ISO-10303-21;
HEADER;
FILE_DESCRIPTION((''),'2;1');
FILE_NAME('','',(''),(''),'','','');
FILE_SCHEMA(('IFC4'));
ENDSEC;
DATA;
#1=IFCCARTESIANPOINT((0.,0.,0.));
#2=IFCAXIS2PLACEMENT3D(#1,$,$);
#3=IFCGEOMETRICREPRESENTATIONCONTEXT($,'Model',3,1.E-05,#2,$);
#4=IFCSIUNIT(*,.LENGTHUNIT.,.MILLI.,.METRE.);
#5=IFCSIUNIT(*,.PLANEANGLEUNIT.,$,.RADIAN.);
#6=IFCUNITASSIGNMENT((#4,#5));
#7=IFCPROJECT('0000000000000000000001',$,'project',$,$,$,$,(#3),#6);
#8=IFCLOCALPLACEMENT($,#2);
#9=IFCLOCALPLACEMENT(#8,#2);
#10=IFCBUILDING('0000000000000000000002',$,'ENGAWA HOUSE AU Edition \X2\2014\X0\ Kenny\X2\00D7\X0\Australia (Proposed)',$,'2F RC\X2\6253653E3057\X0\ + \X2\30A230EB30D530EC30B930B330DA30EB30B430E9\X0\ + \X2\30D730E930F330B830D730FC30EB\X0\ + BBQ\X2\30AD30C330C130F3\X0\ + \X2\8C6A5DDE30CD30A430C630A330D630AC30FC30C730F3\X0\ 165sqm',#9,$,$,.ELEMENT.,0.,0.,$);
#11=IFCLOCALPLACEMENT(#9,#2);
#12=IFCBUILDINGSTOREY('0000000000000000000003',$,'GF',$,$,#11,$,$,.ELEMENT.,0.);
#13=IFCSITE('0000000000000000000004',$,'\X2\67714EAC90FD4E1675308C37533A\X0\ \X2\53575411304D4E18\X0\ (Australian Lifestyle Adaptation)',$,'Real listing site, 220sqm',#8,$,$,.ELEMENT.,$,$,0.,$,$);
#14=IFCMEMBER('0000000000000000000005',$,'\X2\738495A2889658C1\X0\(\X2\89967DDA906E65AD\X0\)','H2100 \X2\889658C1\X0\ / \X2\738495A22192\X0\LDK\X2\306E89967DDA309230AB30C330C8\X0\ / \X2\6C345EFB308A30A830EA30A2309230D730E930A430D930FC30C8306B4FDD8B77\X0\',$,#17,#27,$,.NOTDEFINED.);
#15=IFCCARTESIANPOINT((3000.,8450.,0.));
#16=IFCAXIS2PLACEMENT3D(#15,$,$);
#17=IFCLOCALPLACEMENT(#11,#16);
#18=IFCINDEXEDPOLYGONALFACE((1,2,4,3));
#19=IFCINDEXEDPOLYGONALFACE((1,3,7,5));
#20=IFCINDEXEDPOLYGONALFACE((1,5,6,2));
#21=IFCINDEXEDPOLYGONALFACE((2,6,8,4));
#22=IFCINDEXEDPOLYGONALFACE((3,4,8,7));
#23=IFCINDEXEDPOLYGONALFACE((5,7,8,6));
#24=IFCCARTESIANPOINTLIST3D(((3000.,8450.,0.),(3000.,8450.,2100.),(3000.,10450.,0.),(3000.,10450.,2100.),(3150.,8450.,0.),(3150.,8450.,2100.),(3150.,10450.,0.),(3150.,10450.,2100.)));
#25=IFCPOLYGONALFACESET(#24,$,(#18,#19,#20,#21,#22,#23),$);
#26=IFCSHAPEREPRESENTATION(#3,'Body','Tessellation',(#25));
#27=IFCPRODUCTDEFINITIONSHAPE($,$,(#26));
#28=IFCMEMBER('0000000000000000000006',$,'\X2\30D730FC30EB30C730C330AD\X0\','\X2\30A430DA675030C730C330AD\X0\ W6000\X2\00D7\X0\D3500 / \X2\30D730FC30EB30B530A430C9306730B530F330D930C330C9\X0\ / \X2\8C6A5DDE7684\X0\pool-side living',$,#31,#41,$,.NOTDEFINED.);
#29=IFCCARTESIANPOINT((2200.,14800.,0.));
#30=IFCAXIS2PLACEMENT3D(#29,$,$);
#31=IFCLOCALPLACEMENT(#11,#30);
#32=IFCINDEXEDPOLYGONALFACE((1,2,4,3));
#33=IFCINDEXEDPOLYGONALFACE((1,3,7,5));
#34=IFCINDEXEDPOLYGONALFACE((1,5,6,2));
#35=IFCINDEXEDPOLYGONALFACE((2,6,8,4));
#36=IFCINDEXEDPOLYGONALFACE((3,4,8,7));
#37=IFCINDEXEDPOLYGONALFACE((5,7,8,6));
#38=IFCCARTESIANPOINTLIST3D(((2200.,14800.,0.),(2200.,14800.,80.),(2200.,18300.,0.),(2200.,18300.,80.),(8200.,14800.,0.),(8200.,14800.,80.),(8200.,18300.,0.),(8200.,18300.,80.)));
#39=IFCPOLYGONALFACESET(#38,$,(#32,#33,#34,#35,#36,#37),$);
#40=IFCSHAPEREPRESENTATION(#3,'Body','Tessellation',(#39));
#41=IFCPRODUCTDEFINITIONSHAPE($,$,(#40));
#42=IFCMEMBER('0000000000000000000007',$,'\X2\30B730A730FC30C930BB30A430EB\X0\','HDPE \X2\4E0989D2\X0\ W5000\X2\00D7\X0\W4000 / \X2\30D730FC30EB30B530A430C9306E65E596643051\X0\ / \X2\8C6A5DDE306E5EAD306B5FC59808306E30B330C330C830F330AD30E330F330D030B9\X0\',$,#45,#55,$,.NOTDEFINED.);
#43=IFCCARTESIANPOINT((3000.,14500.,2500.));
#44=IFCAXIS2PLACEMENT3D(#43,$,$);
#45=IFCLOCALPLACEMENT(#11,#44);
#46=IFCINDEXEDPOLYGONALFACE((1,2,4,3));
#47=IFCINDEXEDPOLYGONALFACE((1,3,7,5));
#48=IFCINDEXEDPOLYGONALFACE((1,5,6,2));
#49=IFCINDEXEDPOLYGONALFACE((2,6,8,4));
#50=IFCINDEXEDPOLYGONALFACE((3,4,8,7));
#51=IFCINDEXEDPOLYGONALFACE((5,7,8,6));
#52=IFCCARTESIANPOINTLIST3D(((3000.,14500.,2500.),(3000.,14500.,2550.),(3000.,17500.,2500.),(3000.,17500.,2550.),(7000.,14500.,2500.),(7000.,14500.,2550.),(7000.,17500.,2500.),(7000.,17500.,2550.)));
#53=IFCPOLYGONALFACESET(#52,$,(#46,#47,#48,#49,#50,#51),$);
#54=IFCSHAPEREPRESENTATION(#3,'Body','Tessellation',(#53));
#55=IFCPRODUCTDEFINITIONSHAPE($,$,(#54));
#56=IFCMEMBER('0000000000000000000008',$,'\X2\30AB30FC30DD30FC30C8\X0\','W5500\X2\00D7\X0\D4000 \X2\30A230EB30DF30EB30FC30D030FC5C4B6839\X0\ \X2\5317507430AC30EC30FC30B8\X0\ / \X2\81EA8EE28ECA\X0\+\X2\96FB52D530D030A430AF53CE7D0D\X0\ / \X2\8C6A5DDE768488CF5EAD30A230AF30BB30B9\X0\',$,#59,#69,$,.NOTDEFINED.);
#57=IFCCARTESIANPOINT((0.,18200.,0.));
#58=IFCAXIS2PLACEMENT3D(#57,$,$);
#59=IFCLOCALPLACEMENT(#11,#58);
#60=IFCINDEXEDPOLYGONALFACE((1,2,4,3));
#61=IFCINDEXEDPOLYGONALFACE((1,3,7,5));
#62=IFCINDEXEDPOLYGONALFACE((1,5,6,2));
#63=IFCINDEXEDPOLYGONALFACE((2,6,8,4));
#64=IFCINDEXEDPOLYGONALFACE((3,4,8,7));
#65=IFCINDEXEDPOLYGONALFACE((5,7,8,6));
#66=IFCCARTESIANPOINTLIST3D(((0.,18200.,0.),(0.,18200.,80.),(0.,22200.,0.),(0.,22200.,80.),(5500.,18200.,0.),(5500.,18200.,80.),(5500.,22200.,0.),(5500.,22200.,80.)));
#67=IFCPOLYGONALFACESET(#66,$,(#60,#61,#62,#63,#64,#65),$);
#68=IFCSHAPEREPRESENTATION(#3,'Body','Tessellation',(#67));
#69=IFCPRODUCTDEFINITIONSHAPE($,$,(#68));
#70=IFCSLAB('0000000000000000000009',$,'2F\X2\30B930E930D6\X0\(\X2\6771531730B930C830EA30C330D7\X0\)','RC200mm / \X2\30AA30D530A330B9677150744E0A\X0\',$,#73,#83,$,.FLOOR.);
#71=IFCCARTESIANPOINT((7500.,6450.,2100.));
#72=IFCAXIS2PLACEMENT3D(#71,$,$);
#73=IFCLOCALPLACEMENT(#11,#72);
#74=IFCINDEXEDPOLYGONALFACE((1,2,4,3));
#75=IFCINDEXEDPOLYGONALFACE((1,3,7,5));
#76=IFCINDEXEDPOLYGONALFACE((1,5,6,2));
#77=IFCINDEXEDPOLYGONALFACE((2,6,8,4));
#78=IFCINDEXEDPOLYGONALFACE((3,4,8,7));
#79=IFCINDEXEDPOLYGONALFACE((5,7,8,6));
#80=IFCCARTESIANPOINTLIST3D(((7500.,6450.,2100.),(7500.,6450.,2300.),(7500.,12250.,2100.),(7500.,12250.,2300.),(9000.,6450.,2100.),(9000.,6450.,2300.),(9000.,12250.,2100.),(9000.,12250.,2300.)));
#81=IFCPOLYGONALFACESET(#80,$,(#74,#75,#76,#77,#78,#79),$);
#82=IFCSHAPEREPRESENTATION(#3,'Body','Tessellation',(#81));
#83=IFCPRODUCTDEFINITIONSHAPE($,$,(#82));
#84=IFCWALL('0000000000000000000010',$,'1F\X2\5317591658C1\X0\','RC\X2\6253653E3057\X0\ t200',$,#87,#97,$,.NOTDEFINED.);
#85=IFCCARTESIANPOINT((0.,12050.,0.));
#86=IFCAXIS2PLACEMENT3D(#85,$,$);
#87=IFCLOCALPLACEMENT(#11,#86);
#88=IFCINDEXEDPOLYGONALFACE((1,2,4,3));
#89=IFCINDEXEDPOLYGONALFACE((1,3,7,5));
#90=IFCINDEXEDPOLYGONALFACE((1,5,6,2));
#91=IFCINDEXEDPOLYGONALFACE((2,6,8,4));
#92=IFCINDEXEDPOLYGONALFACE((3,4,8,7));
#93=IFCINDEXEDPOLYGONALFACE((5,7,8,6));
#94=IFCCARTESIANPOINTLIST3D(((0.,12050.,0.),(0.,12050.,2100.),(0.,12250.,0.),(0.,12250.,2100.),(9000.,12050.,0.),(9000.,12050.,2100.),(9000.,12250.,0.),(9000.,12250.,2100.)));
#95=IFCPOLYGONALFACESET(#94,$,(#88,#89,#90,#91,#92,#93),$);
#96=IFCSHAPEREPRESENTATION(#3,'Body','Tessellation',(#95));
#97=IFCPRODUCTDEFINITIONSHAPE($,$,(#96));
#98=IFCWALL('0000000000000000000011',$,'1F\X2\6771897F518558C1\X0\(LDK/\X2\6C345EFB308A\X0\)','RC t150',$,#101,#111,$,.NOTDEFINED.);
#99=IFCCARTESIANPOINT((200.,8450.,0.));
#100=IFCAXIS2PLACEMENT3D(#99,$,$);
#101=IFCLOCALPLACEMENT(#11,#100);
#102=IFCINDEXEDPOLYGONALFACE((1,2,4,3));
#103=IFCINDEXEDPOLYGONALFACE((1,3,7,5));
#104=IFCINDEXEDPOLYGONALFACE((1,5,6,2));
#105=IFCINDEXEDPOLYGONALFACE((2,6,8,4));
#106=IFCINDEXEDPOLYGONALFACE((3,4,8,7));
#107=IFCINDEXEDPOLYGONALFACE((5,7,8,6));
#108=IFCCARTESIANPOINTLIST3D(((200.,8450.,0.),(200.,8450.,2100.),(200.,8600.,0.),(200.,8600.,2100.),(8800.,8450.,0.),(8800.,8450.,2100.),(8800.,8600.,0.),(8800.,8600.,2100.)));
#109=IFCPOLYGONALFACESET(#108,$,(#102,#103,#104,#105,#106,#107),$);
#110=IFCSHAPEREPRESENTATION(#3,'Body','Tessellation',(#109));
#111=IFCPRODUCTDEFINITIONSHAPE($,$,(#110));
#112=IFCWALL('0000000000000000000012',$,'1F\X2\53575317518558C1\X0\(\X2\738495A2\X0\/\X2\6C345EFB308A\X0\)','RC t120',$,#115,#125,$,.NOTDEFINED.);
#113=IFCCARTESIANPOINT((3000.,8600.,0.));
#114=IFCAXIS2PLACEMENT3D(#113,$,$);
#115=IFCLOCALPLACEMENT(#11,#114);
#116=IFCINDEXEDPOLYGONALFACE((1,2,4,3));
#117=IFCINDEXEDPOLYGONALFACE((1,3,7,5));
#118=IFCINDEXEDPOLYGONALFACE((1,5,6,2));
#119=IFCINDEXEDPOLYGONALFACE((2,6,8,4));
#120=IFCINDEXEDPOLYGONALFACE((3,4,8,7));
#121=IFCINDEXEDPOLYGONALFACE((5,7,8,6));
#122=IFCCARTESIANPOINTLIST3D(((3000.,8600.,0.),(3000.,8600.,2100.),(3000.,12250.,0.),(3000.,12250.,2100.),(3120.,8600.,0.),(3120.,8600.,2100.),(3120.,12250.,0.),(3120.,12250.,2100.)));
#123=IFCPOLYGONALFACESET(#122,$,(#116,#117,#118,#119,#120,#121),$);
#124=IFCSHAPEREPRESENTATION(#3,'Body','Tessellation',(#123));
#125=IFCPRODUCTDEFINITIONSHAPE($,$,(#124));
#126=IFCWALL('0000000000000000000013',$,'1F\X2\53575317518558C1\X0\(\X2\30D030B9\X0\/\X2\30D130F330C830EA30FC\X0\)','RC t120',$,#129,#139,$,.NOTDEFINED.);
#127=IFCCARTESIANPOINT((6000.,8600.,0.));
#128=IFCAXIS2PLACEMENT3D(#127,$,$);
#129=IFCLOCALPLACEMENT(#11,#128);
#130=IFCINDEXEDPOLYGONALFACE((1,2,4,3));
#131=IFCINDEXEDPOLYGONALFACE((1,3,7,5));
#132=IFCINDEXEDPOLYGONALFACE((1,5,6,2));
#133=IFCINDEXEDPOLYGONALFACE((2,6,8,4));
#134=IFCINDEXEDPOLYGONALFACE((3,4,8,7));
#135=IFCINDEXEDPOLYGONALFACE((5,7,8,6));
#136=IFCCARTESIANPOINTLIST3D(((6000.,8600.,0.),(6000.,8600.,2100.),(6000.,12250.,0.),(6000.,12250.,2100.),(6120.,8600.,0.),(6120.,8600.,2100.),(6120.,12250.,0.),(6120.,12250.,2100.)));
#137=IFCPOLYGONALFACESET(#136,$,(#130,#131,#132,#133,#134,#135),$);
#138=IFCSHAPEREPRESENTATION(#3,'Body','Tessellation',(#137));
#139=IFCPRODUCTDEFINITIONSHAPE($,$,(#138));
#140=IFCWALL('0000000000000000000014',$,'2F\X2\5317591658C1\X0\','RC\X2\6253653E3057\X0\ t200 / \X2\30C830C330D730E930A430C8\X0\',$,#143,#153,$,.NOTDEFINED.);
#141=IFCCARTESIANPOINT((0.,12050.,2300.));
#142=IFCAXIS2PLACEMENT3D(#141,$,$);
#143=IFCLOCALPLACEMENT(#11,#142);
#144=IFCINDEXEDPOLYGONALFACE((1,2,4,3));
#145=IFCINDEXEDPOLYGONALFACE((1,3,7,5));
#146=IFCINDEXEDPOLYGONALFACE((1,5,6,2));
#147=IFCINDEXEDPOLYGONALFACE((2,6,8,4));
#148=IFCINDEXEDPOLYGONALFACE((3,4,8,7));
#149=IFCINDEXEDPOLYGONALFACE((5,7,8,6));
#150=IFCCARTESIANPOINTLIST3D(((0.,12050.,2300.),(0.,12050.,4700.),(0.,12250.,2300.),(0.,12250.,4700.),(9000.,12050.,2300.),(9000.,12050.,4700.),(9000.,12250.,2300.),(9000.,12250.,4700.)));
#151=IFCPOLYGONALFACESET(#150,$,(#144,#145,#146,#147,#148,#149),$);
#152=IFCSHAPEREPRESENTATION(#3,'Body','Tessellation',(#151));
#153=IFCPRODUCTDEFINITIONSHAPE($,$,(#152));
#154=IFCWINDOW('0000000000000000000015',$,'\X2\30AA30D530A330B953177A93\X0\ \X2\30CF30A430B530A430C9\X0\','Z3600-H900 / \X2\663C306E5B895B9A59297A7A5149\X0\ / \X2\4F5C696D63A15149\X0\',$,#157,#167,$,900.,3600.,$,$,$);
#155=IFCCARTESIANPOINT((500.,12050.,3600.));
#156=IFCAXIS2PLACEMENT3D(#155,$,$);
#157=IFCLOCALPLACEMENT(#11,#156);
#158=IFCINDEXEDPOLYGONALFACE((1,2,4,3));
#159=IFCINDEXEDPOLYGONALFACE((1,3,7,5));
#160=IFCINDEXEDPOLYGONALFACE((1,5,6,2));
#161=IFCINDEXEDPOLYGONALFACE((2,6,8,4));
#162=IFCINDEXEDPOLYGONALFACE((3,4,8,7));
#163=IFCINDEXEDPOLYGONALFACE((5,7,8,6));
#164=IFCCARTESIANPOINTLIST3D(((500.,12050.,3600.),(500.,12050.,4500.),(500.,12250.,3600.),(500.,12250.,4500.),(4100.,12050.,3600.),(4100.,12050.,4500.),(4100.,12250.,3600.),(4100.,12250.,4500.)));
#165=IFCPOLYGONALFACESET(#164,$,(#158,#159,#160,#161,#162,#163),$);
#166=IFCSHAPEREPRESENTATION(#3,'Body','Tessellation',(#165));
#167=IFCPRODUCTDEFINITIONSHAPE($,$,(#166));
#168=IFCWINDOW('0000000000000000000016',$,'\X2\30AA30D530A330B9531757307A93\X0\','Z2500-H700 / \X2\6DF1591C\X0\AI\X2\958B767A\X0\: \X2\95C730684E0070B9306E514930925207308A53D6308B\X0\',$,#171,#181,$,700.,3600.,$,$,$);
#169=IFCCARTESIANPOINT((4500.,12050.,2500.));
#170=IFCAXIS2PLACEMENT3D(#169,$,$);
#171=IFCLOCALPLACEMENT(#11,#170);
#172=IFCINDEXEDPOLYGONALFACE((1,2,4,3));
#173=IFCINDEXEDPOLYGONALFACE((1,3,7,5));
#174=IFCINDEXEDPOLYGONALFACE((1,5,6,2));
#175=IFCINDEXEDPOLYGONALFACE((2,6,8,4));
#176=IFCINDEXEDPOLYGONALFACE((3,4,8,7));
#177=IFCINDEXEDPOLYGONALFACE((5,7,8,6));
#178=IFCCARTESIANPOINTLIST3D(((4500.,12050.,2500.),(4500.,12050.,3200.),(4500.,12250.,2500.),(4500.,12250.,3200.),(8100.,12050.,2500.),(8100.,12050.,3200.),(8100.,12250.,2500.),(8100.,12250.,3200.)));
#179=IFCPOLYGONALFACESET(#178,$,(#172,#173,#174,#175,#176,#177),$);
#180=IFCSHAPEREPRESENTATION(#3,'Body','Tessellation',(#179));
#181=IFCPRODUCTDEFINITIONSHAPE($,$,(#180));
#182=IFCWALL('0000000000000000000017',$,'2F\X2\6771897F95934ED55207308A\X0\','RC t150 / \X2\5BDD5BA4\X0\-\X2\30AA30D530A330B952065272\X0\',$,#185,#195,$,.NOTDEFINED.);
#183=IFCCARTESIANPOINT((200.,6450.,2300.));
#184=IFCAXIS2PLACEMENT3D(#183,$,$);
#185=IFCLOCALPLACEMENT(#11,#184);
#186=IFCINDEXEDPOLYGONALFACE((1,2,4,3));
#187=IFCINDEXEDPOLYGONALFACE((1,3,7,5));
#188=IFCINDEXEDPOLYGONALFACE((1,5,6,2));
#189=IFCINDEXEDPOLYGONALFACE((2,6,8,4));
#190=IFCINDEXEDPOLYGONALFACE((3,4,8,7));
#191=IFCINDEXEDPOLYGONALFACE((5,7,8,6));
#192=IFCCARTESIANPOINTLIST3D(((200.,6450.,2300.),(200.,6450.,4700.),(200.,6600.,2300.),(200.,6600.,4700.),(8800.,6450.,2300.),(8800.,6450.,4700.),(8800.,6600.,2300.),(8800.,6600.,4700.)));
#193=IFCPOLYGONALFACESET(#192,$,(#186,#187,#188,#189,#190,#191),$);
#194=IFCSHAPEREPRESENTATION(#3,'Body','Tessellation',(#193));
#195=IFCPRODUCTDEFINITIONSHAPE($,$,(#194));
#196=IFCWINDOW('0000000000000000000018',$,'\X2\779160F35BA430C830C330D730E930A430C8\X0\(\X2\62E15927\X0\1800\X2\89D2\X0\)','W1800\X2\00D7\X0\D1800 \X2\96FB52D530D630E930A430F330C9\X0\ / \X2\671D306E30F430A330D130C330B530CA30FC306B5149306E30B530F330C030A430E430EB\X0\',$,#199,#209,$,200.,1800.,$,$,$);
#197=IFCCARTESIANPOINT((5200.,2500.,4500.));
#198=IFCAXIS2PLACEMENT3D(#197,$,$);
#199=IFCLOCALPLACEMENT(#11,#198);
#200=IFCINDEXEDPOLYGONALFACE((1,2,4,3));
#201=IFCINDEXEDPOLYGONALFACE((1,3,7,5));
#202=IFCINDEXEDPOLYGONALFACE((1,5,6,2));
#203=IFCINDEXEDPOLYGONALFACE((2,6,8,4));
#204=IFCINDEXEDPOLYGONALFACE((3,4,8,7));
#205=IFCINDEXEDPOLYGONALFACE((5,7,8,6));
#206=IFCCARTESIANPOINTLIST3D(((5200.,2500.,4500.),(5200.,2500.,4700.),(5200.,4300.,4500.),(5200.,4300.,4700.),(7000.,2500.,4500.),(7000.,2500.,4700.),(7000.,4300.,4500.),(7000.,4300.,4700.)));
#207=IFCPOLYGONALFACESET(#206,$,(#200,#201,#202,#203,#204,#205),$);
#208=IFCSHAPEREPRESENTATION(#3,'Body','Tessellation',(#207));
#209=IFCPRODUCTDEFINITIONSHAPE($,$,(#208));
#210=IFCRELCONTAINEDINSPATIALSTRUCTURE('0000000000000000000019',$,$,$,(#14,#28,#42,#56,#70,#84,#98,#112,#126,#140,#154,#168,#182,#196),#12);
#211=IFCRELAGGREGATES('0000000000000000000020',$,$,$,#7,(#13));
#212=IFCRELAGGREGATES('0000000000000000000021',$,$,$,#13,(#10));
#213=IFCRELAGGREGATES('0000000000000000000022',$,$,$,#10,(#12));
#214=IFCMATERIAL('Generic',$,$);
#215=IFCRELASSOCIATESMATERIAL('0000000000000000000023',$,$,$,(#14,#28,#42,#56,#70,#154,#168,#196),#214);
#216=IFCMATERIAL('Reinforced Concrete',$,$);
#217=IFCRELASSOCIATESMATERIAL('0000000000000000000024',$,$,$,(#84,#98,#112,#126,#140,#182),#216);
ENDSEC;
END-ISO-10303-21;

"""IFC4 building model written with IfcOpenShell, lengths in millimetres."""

from ifc_helpers import new_model, si_unit, frame, frame_2d, origin, place, context, project, spatial, rectangle, extrude, material, element, fill, save


model = new_model("IFC4")

# Units and contexts
model_context = context("Model", 3, precision=1e-05, world=origin())
ifc_project = project(units=[si_unit("LENGTHUNIT", "METRE", prefix="MILLI"), si_unit("PLANEANGLEUNIT", "RADIAN")], contexts=[model_context])

# Site, building, storey
site_placement = place(None, origin())
site = spatial("IfcSite", under=ifc_project, at=site_placement, Name="東京都世田谷区 南向き丘 (Australian Lifestyle Adaptation)", ObjectType="Real listing site, 220sqm", CompositionType="ELEMENT", RefElevation=0.0)
building_placement = place(site_placement, origin())
building = spatial("IfcBuilding", under=site, at=building_placement, Name="ENGAWA HOUSE AU Edition — Kenny×Australia (Proposed)", ObjectType="2F RC打放し + アルフレスコペルゴラ + プランジプール + BBQキッチン + 豪州ネイティブガーデン 165sqm", CompositionType="ELEMENT", ElevationOfRefHeight=0.0, ElevationOfTerrain=0.0)
storey_placement = place(building_placement, origin())
storey = spatial("IfcBuildingStorey", under=building, at=storey_placement, Name="GF", CompositionType="ELEMENT", Elevation=0.0)

# Members
ifc_material_1 = material(Name="Generic")
member_1_placement = place(storey_placement, frame((3000.0, 8450.0, 0.0)))
element("IfcMember", 1, at=member_1_placement, inside=storey, material=ifc_material_1, Name="玄関袖壁(視線遮断)", Description="H2100 袖壁 / 玄関→LDKの視線をカット / 水廻りエリアをプライベートに保護", PredefinedType="NOTDEFINED", context=model_context, shape_type="SweptSolid", body=[
    extrude(rectangle(XDim=150.0, YDim=2000.0, at=frame_2d((75.0, 1000.0))), frame((3000.0, 8450.0, 0.0)), (0.0, 0.0, 1.0), 2100.0),
])
member_2_placement = place(storey_placement, frame((2200.0, 14800.0, 0.0)))
element("IfcMember", 2, at=member_2_placement, inside=storey, material=ifc_material_1, Name="プールデッキ", Description="イペ材デッキ W6000×D3500 / プールサイドでサンベッド / 豪州的pool-side living", PredefinedType="NOTDEFINED", context=model_context, shape_type="SweptSolid", body=[
    extrude(rectangle(XDim=6000.0, YDim=3500.0, at=frame_2d((3000.0, 1750.0))), frame((2200.0, 14800.0, 0.0)), (0.0, 0.0, 1.0), 80.0),
])
member_3_placement = place(storey_placement, frame((3000.0, 14500.0, 2500.0)))
element("IfcMember", 3, at=member_3_placement, inside=storey, material=ifc_material_1, Name="シェードセイル", Description="HDPE 三角 W5000×W4000 / プールサイドの日除け / 豪州の庭に必須のコットンキャンバス", PredefinedType="NOTDEFINED", context=model_context, shape_type="SweptSolid", body=[
    extrude(rectangle(XDim=4000.0, YDim=3000.0, at=frame_2d((2000.0, 1500.0))), frame((3000.0, 14500.0, 2500.0)), (0.0, 0.0, 1.0), 50.0),
])
member_4_placement = place(storey_placement, frame((0.0, 18200.0, 0.0)))
element("IfcMember", 4, at=member_4_placement, inside=storey, material=ifc_material_1, Name="カーポート", Description="W5500×D4000 アルミルーバー屋根 北側ガレージ / 自転車+電動バイク収納 / 豪州的裏庭アクセス", PredefinedType="NOTDEFINED", context=model_context, shape_type="SweptSolid", body=[
    extrude(rectangle(XDim=5500.0, YDim=4000.0, at=frame_2d((2750.0, 2000.0))), frame((0.0, 18200.0, 0.0)), (0.0, 0.0, 1.0), 80.0),
])

# Slab
slab_placement = place(storey_placement, frame((7500.0, 6450.0, 2100.0)))
element("IfcSlab", 5, at=slab_placement, inside=storey, material=ifc_material_1, Name="2Fスラブ(東北ストリップ)", Description="RC200mm / オフィス東側上", PredefinedType="FLOOR", context=model_context, shape_type="SweptSolid", body=[
    extrude(rectangle(XDim=1500.0, YDim=5800.0, at=frame_2d((750.0, 2900.0))), frame((7500.0, 6450.0, 2100.0)), (0.0, 0.0, 1.0), 200.0),
])

# Walls
ifc_material_2 = material(Name="Reinforced Concrete")
wall_1_placement = place(storey_placement, frame((0.0, 12050.0, 0.0)))
element("IfcWall", 6, at=wall_1_placement, inside=storey, material=ifc_material_2, Name="1F北外壁", Description="RC打放し t200", PredefinedType="NOTDEFINED", context=model_context, shape_type="SweptSolid", body=[
    extrude(rectangle(XDim=9000.0, YDim=200.0, at=frame_2d((4500.0, 100.0))), frame((0.0, 12050.0, 0.0)), (0.0, 0.0, 1.0), 2100.0),
])
wall_2_placement = place(storey_placement, frame((200.0, 8450.0, 0.0)))
element("IfcWall", 7, at=wall_2_placement, inside=storey, material=ifc_material_2, Name="1F東西内壁(LDK/水廻り)", Description="RC t150", PredefinedType="NOTDEFINED", context=model_context, shape_type="SweptSolid", body=[
    extrude(rectangle(XDim=8600.0, YDim=150.0, at=frame_2d((4300.0, 75.0))), frame((200.0, 8450.0, 0.0)), (0.0, 0.0, 1.0), 2100.0),
])
wall_3_placement = place(storey_placement, frame((3000.0, 8600.0, 0.0)))
element("IfcWall", 8, at=wall_3_placement, inside=storey, material=ifc_material_2, Name="1F南北内壁(玄関/水廻り)", Description="RC t120", PredefinedType="NOTDEFINED", context=model_context, shape_type="SweptSolid", body=[
    extrude(rectangle(XDim=120.0, YDim=3650.0, at=frame_2d((60.0, 1825.0))), frame((3000.0, 8600.0, 0.0)), (0.0, 0.0, 1.0), 2100.0),
])
wall_4_placement = place(storey_placement, frame((6000.0, 8600.0, 0.0)))
element("IfcWall", 9, at=wall_4_placement, inside=storey, material=ifc_material_2, Name="1F南北内壁(バス/パントリー)", Description="RC t120", PredefinedType="NOTDEFINED", context=model_context, shape_type="SweptSolid", body=[
    extrude(rectangle(XDim=120.0, YDim=3650.0, at=frame_2d((60.0, 1825.0))), frame((6000.0, 8600.0, 0.0)), (0.0, 0.0, 1.0), 2100.0),
])

# Wall, openings, windows
wall_5_placement = place(storey_placement, frame((0.0, 12050.0, 2300.0)))
wall_5 = element("IfcWall", 10, at=wall_5_placement, inside=storey, material=ifc_material_2, Name="2F北外壁", Description="RC打放し t200 / トップライト", PredefinedType="NOTDEFINED", context=model_context, shape_type="SweptSolid", body=[
    extrude(rectangle(XDim=9000.0, YDim=200.0, at=frame_2d((4500.0, 100.0))), frame((0.0, 12050.0, 2300.0)), (0.0, 0.0, 1.0), 2400.0),
])
opening_1_placement = place(storey_placement, frame((500.0, 12050.0, 3600.0)))
opening_1 = element("IfcOpeningElement", 11, at=opening_1_placement, cuts=wall_5, PredefinedType="NOTDEFINED", context=model_context, shape_type="SweptSolid", body=[
    extrude(rectangle(XDim=3600.0, YDim=200.0, at=frame_2d((1800.0, 100.0))), frame((500.0, 12050.0, 3600.0)), (0.0, 0.0, 1.0), 900.0),
])
opening_2_placement = place(storey_placement, frame((4500.0, 12050.0, 2500.0)))
opening_2 = element("IfcOpeningElement", 12, at=opening_2_placement, cuts=wall_5, PredefinedType="NOTDEFINED", context=model_context, shape_type="SweptSolid", body=[
    extrude(rectangle(XDim=3600.0, YDim=200.0, at=frame_2d((1800.0, 100.0))), frame((4500.0, 12050.0, 2500.0)), (0.0, 0.0, 1.0), 700.0),
])
window_1_placement = place(storey_placement, frame((500.0, 12050.0, 3600.0)))
window_1 = element("IfcWindow", 13, at=window_1_placement, inside=storey, material=ifc_material_1, Name="オフィス北窓 ハイサイド", Description="Z3600-H900 / 昼の安定天空光 / 作業採光", OverallHeight=900.0, OverallWidth=3600.0, context=model_context, shape_type="SweptSolid", body=[
    extrude(rectangle(XDim=3600.0, YDim=200.0, at=frame_2d((1800.0, 100.0))), frame((500.0, 12050.0, 3600.0)), (0.0, 0.0, 1.0), 900.0),
])
fill(opening_1, window_1)
window_2_placement = place(storey_placement, frame((4500.0, 12050.0, 2500.0)))
window_2 = element("IfcWindow", 14, at=window_2_placement, inside=storey, material=ifc_material_1, Name="オフィス北地窓", Description="Z2500-H700 / 深夜AI開発: 闇と一点の光を切り取る", OverallHeight=700.0, OverallWidth=3600.0, context=model_context, shape_type="SweptSolid", body=[
    extrude(rectangle(XDim=3600.0, YDim=200.0, at=frame_2d((1800.0, 100.0))), frame((4500.0, 12050.0, 2500.0)), (0.0, 0.0, 1.0), 700.0),
])
fill(opening_2, window_2)

# Wall
wall_6_placement = place(storey_placement, frame((200.0, 6450.0, 2300.0)))
element("IfcWall", 15, at=wall_6_placement, inside=storey, material=ifc_material_2, Name="2F東西間仕切り", Description="RC t150 / 寝室-オフィス分割", PredefinedType="NOTDEFINED", context=model_context, shape_type="SweptSolid", body=[
    extrude(rectangle(XDim=8600.0, YDim=150.0, at=frame_2d((4300.0, 75.0))), frame((200.0, 6450.0, 2300.0)), (0.0, 0.0, 1.0), 2400.0),
])

# Window
window_3_placement = place(storey_placement, frame((5200.0, 2500.0, 4500.0)))
element("IfcWindow", 16, at=window_3_placement, inside=storey, material=ifc_material_1, Name="瞑想室トップライト(拡大1800角)", Description="W1800×D1800 電動ブラインド / 朝のヴィパッサナーに光のサンダイヤル", OverallHeight=200.0, OverallWidth=1800.0, context=model_context, shape_type="SweptSolid", body=[
    extrude(rectangle(XDim=1800.0, YDim=1800.0, at=frame_2d((900.0, 900.0))), frame((5200.0, 2500.0, 4500.0)), (0.0, 0.0, 1.0), 200.0),
])

save(model, "model.ifc")
